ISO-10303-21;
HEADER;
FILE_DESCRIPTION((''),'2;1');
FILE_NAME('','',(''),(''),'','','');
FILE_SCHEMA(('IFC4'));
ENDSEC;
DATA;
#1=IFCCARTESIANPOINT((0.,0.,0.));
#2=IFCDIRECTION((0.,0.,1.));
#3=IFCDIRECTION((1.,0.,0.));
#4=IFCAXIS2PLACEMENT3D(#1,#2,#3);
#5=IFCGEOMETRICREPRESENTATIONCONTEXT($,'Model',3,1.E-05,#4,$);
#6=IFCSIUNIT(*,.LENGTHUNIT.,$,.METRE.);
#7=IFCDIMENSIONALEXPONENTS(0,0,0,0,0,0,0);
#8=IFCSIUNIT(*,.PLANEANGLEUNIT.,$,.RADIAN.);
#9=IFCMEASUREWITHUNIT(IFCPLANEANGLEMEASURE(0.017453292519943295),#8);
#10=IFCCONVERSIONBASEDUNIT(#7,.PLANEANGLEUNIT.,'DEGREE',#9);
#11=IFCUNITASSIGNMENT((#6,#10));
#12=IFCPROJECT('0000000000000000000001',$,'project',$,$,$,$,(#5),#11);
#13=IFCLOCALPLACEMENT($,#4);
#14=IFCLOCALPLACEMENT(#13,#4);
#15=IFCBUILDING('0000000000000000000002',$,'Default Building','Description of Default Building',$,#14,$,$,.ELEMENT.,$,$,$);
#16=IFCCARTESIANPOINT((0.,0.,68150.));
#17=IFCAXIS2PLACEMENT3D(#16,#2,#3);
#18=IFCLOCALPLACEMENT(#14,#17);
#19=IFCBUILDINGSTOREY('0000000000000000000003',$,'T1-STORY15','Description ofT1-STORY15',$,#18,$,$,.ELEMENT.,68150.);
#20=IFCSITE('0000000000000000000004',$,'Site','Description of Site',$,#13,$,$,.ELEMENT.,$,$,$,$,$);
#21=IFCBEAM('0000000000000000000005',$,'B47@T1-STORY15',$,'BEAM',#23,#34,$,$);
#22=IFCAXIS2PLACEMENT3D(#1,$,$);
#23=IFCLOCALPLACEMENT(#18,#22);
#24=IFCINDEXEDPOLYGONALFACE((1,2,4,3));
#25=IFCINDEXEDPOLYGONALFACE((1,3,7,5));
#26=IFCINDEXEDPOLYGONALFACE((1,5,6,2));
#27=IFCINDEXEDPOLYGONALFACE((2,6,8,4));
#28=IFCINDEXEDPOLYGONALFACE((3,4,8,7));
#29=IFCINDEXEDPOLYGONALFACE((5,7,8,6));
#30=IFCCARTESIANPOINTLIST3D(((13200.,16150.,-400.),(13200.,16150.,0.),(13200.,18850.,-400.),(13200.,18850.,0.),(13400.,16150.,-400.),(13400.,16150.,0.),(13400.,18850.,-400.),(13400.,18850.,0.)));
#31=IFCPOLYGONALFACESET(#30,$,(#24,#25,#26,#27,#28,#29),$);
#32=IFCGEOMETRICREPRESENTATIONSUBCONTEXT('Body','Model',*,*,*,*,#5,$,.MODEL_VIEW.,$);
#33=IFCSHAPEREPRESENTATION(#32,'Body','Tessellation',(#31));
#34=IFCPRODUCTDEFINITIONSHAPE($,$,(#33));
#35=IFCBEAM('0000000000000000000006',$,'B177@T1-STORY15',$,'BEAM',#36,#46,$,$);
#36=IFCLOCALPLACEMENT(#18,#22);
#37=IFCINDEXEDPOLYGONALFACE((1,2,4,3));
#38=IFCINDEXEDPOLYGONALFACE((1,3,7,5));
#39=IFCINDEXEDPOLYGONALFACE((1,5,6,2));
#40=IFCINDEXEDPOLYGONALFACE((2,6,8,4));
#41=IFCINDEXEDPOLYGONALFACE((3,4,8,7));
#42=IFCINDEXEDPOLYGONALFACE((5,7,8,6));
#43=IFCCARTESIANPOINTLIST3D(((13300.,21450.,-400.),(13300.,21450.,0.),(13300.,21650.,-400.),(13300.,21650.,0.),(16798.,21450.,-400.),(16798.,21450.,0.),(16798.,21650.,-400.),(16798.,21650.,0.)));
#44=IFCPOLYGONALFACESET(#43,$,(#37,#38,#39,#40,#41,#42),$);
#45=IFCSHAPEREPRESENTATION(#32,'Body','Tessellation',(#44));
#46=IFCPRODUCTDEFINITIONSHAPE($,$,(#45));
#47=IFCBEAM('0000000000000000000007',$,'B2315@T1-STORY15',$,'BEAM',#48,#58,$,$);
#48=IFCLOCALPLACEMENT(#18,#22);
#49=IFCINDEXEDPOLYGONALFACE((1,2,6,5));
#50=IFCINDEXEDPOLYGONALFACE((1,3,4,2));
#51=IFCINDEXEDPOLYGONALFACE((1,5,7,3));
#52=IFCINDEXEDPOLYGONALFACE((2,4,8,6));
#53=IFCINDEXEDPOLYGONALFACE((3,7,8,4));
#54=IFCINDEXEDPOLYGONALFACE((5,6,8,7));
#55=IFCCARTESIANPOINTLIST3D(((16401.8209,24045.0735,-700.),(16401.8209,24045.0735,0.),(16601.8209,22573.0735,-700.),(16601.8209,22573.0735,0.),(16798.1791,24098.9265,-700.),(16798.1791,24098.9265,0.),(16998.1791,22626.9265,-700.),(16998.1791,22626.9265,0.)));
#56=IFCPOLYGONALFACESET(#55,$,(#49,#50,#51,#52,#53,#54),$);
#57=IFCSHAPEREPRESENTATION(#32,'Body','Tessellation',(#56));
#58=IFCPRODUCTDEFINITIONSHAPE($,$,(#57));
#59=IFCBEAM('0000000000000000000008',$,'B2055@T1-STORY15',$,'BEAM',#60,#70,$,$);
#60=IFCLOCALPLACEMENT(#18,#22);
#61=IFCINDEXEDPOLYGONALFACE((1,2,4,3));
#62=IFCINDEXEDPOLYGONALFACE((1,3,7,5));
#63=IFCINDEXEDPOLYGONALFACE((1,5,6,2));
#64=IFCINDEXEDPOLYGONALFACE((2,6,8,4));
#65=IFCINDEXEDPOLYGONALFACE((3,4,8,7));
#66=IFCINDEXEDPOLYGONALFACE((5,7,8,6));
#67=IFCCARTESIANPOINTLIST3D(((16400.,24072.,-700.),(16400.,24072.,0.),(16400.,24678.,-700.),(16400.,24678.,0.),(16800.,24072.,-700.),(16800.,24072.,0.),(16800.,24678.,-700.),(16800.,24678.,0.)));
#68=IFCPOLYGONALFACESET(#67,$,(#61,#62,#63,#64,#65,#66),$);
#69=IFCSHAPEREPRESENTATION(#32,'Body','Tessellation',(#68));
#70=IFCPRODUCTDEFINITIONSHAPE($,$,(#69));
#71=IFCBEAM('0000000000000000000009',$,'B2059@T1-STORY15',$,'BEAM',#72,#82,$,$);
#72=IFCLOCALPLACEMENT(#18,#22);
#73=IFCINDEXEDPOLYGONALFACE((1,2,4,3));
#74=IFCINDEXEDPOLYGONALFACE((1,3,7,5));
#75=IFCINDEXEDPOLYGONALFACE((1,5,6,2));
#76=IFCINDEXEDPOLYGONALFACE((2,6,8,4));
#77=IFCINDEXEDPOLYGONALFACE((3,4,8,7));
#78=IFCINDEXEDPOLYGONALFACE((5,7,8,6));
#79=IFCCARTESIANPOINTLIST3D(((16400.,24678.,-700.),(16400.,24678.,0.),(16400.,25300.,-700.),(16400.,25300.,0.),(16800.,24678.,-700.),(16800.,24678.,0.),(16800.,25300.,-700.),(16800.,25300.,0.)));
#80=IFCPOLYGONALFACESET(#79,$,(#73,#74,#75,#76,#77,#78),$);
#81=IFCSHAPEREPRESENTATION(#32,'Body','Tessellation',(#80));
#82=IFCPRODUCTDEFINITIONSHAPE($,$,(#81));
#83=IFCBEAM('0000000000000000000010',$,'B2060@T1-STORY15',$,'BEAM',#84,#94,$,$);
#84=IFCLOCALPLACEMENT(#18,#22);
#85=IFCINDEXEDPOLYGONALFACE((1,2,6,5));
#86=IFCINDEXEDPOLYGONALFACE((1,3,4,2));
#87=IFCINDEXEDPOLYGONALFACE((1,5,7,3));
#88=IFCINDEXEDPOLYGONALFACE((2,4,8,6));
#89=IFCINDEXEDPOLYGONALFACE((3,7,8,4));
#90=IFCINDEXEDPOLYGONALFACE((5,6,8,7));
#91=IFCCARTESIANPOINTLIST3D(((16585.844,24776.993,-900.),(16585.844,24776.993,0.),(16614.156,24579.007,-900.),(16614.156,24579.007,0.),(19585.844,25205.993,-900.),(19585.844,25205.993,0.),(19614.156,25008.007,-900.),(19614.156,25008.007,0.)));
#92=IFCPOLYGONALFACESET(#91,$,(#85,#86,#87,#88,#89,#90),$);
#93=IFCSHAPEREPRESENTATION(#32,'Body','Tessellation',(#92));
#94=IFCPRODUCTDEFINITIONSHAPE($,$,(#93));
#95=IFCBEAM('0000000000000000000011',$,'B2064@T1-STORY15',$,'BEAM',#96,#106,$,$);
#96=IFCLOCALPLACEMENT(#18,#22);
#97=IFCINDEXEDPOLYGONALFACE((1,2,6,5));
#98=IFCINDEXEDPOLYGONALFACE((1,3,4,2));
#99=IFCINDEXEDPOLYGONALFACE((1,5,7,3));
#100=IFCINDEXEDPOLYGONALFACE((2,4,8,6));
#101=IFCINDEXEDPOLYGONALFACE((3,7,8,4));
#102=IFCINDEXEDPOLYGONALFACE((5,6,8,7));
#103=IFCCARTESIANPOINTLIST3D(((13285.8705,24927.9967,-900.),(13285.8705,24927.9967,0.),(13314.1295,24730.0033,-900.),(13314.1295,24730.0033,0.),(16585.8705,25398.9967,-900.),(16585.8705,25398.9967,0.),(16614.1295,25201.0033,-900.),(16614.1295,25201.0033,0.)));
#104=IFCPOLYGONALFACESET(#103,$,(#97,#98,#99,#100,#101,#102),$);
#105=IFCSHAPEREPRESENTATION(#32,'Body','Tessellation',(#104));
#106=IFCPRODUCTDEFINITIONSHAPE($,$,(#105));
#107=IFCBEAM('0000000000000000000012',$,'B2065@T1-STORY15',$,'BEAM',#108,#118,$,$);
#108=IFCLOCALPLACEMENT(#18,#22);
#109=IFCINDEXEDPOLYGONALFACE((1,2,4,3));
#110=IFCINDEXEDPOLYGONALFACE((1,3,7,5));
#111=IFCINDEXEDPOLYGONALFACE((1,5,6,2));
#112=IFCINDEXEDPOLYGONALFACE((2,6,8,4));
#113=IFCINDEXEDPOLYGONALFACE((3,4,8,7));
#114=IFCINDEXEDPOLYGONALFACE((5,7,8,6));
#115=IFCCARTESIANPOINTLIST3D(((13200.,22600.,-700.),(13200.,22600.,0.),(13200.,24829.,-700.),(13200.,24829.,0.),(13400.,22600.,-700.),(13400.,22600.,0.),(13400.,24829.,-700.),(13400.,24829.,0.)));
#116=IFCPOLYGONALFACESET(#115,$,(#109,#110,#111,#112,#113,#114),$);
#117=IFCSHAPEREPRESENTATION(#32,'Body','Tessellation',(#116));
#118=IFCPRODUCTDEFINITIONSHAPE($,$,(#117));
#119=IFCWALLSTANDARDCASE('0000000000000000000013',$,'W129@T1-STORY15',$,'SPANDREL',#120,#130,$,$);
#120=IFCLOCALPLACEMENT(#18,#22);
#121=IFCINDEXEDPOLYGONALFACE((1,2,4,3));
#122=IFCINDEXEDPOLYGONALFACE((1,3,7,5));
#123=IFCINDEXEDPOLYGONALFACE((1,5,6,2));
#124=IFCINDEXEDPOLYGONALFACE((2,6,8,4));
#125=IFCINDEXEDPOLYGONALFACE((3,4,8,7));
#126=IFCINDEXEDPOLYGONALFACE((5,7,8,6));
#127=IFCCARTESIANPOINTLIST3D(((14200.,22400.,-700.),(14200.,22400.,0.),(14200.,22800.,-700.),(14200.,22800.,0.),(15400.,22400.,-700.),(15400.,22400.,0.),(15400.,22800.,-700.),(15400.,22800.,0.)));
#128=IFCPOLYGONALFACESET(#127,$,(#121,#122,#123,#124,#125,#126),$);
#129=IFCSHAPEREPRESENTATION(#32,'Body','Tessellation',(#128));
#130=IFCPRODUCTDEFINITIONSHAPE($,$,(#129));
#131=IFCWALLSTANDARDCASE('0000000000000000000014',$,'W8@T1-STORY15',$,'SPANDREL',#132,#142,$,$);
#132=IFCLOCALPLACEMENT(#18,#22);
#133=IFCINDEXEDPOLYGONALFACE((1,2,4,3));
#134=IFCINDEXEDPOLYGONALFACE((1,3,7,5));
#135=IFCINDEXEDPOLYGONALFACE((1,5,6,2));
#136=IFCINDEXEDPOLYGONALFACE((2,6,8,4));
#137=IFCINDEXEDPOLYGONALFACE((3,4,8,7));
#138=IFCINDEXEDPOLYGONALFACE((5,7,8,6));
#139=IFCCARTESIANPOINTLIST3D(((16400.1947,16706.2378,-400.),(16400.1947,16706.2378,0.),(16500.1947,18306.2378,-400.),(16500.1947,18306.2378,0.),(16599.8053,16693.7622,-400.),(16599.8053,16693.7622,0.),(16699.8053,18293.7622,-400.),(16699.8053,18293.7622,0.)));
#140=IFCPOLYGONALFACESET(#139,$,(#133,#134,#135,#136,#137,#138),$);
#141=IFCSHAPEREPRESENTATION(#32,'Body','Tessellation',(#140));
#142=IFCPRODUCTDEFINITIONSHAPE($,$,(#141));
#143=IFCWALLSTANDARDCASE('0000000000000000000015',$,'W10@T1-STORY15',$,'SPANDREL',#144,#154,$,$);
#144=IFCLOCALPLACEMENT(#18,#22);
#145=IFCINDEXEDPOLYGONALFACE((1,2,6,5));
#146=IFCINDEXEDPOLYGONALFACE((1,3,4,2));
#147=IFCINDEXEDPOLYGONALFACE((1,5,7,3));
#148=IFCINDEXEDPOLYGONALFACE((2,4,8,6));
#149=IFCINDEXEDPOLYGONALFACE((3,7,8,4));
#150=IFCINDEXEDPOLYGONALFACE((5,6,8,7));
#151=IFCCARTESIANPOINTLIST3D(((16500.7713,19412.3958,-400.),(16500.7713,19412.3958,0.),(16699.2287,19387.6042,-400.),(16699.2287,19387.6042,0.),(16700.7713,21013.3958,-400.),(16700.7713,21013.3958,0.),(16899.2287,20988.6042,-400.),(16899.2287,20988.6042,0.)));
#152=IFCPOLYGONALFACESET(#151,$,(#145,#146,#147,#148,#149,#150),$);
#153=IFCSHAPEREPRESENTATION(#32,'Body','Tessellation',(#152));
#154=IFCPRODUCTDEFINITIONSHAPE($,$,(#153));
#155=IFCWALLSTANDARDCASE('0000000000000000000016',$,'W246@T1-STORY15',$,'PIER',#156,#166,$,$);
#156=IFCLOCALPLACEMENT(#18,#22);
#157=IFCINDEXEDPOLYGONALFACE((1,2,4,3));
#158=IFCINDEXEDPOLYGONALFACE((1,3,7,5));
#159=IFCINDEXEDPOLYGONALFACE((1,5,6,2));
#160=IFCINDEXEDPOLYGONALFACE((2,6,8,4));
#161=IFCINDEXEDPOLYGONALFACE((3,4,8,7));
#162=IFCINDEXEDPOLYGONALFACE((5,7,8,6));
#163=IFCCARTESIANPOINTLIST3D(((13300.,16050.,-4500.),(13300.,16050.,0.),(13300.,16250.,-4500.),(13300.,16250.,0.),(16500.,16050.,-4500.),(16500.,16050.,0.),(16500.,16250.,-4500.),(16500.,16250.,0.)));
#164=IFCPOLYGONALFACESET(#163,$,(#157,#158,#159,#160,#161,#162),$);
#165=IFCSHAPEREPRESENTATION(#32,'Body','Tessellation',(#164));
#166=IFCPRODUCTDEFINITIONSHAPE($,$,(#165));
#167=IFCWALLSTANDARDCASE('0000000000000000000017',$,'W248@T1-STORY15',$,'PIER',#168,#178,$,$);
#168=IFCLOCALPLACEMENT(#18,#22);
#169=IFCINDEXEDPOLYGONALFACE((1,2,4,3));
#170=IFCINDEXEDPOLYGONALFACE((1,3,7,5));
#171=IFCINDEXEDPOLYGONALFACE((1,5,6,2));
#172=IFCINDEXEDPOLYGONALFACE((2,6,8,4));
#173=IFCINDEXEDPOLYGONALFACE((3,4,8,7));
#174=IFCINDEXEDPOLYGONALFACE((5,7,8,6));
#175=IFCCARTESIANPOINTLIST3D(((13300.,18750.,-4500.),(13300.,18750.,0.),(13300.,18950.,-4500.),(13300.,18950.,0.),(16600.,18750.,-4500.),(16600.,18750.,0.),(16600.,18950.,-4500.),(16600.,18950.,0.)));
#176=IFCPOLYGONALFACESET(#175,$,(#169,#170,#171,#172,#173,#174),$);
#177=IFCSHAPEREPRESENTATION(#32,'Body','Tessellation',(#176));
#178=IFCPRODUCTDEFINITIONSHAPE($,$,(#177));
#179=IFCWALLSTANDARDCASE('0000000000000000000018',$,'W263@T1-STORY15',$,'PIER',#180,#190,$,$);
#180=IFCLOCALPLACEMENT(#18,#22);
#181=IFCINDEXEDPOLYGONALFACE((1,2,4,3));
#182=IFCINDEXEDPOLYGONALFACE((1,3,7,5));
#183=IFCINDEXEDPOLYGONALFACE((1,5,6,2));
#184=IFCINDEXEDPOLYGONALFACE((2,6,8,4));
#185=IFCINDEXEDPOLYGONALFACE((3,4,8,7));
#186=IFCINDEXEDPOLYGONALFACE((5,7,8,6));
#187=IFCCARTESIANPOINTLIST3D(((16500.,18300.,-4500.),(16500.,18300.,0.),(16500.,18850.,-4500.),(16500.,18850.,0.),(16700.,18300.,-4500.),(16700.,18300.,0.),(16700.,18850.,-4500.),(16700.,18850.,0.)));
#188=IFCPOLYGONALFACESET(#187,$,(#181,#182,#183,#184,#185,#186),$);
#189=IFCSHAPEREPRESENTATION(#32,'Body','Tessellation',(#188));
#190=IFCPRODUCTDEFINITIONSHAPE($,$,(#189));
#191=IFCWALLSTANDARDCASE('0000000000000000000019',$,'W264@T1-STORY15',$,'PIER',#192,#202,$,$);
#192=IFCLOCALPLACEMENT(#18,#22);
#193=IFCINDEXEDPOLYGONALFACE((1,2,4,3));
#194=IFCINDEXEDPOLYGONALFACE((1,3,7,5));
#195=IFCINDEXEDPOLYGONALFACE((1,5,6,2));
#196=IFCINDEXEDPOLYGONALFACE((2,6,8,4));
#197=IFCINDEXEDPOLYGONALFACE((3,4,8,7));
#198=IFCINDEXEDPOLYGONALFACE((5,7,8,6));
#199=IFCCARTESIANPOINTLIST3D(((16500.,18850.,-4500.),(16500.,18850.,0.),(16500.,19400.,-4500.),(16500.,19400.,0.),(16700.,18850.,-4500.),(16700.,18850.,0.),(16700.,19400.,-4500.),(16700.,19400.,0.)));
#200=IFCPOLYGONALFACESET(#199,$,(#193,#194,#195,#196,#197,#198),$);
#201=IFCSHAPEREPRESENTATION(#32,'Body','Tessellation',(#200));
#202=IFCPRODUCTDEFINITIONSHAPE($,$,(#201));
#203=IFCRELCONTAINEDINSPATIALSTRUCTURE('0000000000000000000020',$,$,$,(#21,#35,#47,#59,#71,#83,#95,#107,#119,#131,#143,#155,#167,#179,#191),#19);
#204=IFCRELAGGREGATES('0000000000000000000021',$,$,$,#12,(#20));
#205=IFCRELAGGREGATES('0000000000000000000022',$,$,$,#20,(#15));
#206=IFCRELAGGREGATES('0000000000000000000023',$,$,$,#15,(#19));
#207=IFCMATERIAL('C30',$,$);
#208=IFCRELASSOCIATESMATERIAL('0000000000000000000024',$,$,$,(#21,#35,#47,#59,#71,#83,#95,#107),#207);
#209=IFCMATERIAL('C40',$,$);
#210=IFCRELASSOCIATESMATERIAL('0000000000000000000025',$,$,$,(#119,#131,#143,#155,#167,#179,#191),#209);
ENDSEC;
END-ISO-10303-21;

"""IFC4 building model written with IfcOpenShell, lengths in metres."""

from ifc_helpers import new_model, entity, si_unit, converted_unit, frame, origin_with_axes, place, context, subcontext, project, spatial, indexed_curve, rectangle, outline, extrude, material, element, save


model = new_model("IFC4")

# Units and contexts
model_context = context("Model", 3, precision=1e-05, world=origin_with_axes())
body_context = subcontext(model_context, "Body", "Model", "MODEL_VIEW")
ifc_project = project(units=[si_unit("LENGTHUNIT", "METRE"), converted_unit("PLANEANGLEUNIT", "DEGREE", entity("IfcPlaneAngleMeasure", 0.017453292519943295), si_unit("PLANEANGLEUNIT", "RADIAN"), dimensions=[0, 0, 0, 0, 0, 0, 0])], contexts=[model_context])

# Site, building, storey
site_placement = place(None, origin_with_axes())
site = spatial("IfcSite", under=ifc_project, at=site_placement, Name="Site", Description="Description of Site", CompositionType="ELEMENT")
building_placement = place(site_placement, origin_with_axes())
building = spatial("IfcBuilding", under=site, at=building_placement, Name="Default Building", Description="Description of Default Building", CompositionType="ELEMENT")
storey_placement = place(building_placement, frame((0.0, 0.0, 68150.0), z_axis=(0.0, 0.0, 1.0), x_axis=(1.0, 0.0, 0.0)))
storey = spatial("IfcBuildingStorey", under=building, at=storey_placement, Name="T1-STORY15", Description="Description ofT1-STORY15", CompositionType="ELEMENT", Elevation=68150.0)

# Beams
ifc_material_1 = material(Name="C30")
beam_1_placement = place(storey_placement, frame((13300.0, 16150.0, -200.0), z_axis=(0.0, 1.0, 0.0), x_axis=(-1.0, 0.0, 0.0)))
element("IfcBeam", 1, at=beam_1_placement, inside=storey, material=ifc_material_1, Name="B47@T1-STORY15", ObjectType="BEAM", context=body_context, shape_type="SweptSolid", body=[
    extrude(rectangle(XDim=200.0, YDim=400.0), origin_with_axes(), (0.0, 0.0, 1.0), 2700.0),
])
beam_2_placement = place(storey_placement, frame((13300.0, 21550.0, -200.0), z_axis=(1.0, 0.0, 0.0), x_axis=(0.0, 1.0, 0.0)))
element("IfcBeam", 2, at=beam_2_placement, inside=storey, material=ifc_material_1, Name="B177@T1-STORY15", ObjectType="BEAM", context=body_context, shape_type="SweptSolid", body=[
    extrude(rectangle(XDim=200.0, YDim=400.0), origin_with_axes(), (0.0, 0.0, 1.0), 3498.0),
])
beam_3_placement = place(storey_placement, frame((16600.0, 24072.0, -350.0), z_axis=(0.134633, -0.990896, 0.0), x_axis=(0.990896, 0.134633, 0.0)))
element("IfcBeam", 3, at=beam_3_placement, inside=storey, material=ifc_material_1, Name="B2315@T1-STORY15", ObjectType="BEAM", context=body_context, shape_type="SweptSolid", body=[
    extrude(rectangle(XDim=400.0, YDim=700.0), origin_with_axes(), (0.0, 0.0, 1.0), 1485.5248),
])
beam_4_placement = place(storey_placement, frame((16600.0, 24072.0, -350.0), z_axis=(0.0, 1.0, 0.0), x_axis=(-1.0, 0.0, 0.0)))
element("IfcBeam", 4, at=beam_4_placement, inside=storey, material=ifc_material_1, Name="B2055@T1-STORY15", ObjectType="BEAM", context=body_context, shape_type="SweptSolid", body=[
    extrude(rectangle(XDim=400.0, YDim=700.0), origin_with_axes(), (0.0, 0.0, 1.0), 606.0),
])
beam_5_placement = place(storey_placement, frame((16600.0, 24678.0, -350.0), z_axis=(0.0, 1.0, 0.0), x_axis=(-1.0, 0.0, 0.0)))
element("IfcBeam", 5, at=beam_5_placement, inside=storey, material=ifc_material_1, Name="B2059@T1-STORY15", ObjectType="BEAM", context=body_context, shape_type="SweptSolid", body=[
    extrude(rectangle(XDim=400.0, YDim=700.0), origin_with_axes(), (0.0, 0.0, 1.0), 622.0),
])
beam_6_placement = place(storey_placement, frame((16600.0, 24678.0, -450.0), z_axis=(0.98993, 0.14156, 0.0), x_axis=(-0.14156, 0.98993, 0.0)))
element("IfcBeam", 6, at=beam_6_placement, inside=storey, material=ifc_material_1, Name="B2060@T1-STORY15", ObjectType="BEAM", context=body_context, shape_type="SweptSolid", body=[
    extrude(rectangle(XDim=200.0, YDim=900.0), origin_with_axes(), (0.0, 0.0, 1.0), 3030.5183),
])
beam_7_placement = place(storey_placement, frame((13300.0, 24829.0, -450.0), z_axis=(0.989967, 0.141295, 0.0), x_axis=(-0.141295, 0.989967, 0.0)))
element("IfcBeam", 7, at=beam_7_placement, inside=storey, material=ifc_material_1, Name="B2064@T1-STORY15", ObjectType="BEAM", context=body_context, shape_type="SweptSolid", body=[
    extrude(rectangle(XDim=200.0, YDim=900.0), origin_with_axes(), (0.0, 0.0, 1.0), 3333.4428),
])
beam_8_placement = place(storey_placement, frame((13300.0, 22600.0, -350.0), z_axis=(0.0, 1.0, 0.0), x_axis=(-1.0, 0.0, 0.0)))
element("IfcBeam", 8, at=beam_8_placement, inside=storey, material=ifc_material_1, Name="B2065@T1-STORY15", ObjectType="BEAM", context=body_context, shape_type="SweptSolid", body=[
    extrude(rectangle(XDim=200.0, YDim=700.0), origin_with_axes(), (0.0, 0.0, 1.0), 2229.0),
])

# Walls
ifc_material_2 = material(Name="C40")
wall_1_placement = place(storey_placement, frame((14200.0, 22600.0, -700.0), z_axis=(0.0, 0.0, 1.0), x_axis=(1.0, 0.0, 0.0)))
element("IfcWallStandardCase", 9, at=wall_1_placement, inside=storey, material=ifc_material_2, Name="W129@T1-STORY15", ObjectType="SPANDREL", context=body_context, shape_type="SweptSolid", body=[
    extrude(outline(indexed_curve([(0.0, -200.0), (0.0, 200.0), (1200.0, 200.0), (1200.0, -200.0), (0.0, -200.0)], self_intersect=False)), origin_with_axes(), (0.0, 0.0, 1.0), 700.0),
])
wall_2_placement = place(storey_placement, frame((16500.0, 16700.0, -400.0), z_axis=(0.0, 0.0, 1.0), x_axis=(0.062378, 0.998053, 0.0)))
element("IfcWallStandardCase", 10, at=wall_2_placement, inside=storey, material=ifc_material_2, Name="W8@T1-STORY15", ObjectType="SPANDREL", context=body_context, shape_type="SweptSolid", body=[
    extrude(outline(indexed_curve([(0.0, -100.0), (0.0, 100.0), (1603.122, 100.0), (1603.122, -100.0), (0.0, -100.0)], self_intersect=False)), origin_with_axes(), (0.0, 0.0, 1.0), 400.0),
])
wall_3_placement = place(storey_placement, frame((16600.0, 19400.0, -400.0), z_axis=(0.0, 0.0, 1.0), x_axis=(0.123958, 0.992287, 0.0)))
element("IfcWallStandardCase", 11, at=wall_3_placement, inside=storey, material=ifc_material_2, Name="W10@T1-STORY15", ObjectType="SPANDREL", context=body_context, shape_type="SweptSolid", body=[
    extrude(outline(indexed_curve([(0.0, -100.0), (0.0, 100.0), (1613.4438, 100.0), (1613.4438, -100.0), (0.0, -100.0)], self_intersect=False)), origin_with_axes(), (0.0, 0.0, 1.0), 400.0),
])
wall_4_placement = place(storey_placement, frame((13300.0, 16150.0, -4500.0), z_axis=(0.0, 0.0, 1.0), x_axis=(1.0, 0.0, 0.0)))
element("IfcWallStandardCase", 12, at=wall_4_placement, inside=storey, material=ifc_material_2, Name="W246@T1-STORY15", ObjectType="PIER", context=body_context, shape_type="SweptSolid", body=[
    extrude(outline(indexed_curve([(0.0, -100.0), (0.0, 100.0), (3200.0, 100.0), (3200.0, -100.0), (0.0, -100.0)], self_intersect=False)), origin_with_axes(), (0.0, 0.0, 1.0), 4500.0),
])
wall_5_placement = place(storey_placement, frame((13300.0, 18850.0, -4500.0), z_axis=(0.0, 0.0, 1.0), x_axis=(1.0, 0.0, 0.0)))
element("IfcWallStandardCase", 13, at=wall_5_placement, inside=storey, material=ifc_material_2, Name="W248@T1-STORY15", ObjectType="PIER", context=body_context, shape_type="SweptSolid", body=[
    extrude(outline(indexed_curve([(0.0, -100.0), (0.0, 100.0), (3300.0, 100.0), (3300.0, -100.0), (0.0, -100.0)], self_intersect=False)), origin_with_axes(), (0.0, 0.0, 1.0), 4500.0),
])
for number, where, z_axis, x_axis, name in (
    (14, (16600.0, 18300.0, -4500.0), (0.0, 0.0, 1.0), (0.0, 1.0, 0.0), "W263@T1-STORY15"),
    (15, (16600.0, 18850.0, -4500.0), (0.0, 0.0, 1.0), (0.0, 1.0, 0.0), "W264@T1-STORY15"),
):
    element("IfcWallStandardCase", number, at=place(storey_placement, frame(where, z_axis=z_axis, x_axis=x_axis)), inside=storey, material=ifc_material_2, Name=name, ObjectType="PIER", context=body_context, shape_type="SweptSolid", body=[
        extrude(outline(indexed_curve([(0.0, -100.0), (0.0, 100.0), (550.0, 100.0), (550.0, -100.0), (0.0, -100.0)], self_intersect=False)), origin_with_axes(), (0.0, 0.0, 1.0), 4500.0),
    ])

save(model, "model.ifc")
